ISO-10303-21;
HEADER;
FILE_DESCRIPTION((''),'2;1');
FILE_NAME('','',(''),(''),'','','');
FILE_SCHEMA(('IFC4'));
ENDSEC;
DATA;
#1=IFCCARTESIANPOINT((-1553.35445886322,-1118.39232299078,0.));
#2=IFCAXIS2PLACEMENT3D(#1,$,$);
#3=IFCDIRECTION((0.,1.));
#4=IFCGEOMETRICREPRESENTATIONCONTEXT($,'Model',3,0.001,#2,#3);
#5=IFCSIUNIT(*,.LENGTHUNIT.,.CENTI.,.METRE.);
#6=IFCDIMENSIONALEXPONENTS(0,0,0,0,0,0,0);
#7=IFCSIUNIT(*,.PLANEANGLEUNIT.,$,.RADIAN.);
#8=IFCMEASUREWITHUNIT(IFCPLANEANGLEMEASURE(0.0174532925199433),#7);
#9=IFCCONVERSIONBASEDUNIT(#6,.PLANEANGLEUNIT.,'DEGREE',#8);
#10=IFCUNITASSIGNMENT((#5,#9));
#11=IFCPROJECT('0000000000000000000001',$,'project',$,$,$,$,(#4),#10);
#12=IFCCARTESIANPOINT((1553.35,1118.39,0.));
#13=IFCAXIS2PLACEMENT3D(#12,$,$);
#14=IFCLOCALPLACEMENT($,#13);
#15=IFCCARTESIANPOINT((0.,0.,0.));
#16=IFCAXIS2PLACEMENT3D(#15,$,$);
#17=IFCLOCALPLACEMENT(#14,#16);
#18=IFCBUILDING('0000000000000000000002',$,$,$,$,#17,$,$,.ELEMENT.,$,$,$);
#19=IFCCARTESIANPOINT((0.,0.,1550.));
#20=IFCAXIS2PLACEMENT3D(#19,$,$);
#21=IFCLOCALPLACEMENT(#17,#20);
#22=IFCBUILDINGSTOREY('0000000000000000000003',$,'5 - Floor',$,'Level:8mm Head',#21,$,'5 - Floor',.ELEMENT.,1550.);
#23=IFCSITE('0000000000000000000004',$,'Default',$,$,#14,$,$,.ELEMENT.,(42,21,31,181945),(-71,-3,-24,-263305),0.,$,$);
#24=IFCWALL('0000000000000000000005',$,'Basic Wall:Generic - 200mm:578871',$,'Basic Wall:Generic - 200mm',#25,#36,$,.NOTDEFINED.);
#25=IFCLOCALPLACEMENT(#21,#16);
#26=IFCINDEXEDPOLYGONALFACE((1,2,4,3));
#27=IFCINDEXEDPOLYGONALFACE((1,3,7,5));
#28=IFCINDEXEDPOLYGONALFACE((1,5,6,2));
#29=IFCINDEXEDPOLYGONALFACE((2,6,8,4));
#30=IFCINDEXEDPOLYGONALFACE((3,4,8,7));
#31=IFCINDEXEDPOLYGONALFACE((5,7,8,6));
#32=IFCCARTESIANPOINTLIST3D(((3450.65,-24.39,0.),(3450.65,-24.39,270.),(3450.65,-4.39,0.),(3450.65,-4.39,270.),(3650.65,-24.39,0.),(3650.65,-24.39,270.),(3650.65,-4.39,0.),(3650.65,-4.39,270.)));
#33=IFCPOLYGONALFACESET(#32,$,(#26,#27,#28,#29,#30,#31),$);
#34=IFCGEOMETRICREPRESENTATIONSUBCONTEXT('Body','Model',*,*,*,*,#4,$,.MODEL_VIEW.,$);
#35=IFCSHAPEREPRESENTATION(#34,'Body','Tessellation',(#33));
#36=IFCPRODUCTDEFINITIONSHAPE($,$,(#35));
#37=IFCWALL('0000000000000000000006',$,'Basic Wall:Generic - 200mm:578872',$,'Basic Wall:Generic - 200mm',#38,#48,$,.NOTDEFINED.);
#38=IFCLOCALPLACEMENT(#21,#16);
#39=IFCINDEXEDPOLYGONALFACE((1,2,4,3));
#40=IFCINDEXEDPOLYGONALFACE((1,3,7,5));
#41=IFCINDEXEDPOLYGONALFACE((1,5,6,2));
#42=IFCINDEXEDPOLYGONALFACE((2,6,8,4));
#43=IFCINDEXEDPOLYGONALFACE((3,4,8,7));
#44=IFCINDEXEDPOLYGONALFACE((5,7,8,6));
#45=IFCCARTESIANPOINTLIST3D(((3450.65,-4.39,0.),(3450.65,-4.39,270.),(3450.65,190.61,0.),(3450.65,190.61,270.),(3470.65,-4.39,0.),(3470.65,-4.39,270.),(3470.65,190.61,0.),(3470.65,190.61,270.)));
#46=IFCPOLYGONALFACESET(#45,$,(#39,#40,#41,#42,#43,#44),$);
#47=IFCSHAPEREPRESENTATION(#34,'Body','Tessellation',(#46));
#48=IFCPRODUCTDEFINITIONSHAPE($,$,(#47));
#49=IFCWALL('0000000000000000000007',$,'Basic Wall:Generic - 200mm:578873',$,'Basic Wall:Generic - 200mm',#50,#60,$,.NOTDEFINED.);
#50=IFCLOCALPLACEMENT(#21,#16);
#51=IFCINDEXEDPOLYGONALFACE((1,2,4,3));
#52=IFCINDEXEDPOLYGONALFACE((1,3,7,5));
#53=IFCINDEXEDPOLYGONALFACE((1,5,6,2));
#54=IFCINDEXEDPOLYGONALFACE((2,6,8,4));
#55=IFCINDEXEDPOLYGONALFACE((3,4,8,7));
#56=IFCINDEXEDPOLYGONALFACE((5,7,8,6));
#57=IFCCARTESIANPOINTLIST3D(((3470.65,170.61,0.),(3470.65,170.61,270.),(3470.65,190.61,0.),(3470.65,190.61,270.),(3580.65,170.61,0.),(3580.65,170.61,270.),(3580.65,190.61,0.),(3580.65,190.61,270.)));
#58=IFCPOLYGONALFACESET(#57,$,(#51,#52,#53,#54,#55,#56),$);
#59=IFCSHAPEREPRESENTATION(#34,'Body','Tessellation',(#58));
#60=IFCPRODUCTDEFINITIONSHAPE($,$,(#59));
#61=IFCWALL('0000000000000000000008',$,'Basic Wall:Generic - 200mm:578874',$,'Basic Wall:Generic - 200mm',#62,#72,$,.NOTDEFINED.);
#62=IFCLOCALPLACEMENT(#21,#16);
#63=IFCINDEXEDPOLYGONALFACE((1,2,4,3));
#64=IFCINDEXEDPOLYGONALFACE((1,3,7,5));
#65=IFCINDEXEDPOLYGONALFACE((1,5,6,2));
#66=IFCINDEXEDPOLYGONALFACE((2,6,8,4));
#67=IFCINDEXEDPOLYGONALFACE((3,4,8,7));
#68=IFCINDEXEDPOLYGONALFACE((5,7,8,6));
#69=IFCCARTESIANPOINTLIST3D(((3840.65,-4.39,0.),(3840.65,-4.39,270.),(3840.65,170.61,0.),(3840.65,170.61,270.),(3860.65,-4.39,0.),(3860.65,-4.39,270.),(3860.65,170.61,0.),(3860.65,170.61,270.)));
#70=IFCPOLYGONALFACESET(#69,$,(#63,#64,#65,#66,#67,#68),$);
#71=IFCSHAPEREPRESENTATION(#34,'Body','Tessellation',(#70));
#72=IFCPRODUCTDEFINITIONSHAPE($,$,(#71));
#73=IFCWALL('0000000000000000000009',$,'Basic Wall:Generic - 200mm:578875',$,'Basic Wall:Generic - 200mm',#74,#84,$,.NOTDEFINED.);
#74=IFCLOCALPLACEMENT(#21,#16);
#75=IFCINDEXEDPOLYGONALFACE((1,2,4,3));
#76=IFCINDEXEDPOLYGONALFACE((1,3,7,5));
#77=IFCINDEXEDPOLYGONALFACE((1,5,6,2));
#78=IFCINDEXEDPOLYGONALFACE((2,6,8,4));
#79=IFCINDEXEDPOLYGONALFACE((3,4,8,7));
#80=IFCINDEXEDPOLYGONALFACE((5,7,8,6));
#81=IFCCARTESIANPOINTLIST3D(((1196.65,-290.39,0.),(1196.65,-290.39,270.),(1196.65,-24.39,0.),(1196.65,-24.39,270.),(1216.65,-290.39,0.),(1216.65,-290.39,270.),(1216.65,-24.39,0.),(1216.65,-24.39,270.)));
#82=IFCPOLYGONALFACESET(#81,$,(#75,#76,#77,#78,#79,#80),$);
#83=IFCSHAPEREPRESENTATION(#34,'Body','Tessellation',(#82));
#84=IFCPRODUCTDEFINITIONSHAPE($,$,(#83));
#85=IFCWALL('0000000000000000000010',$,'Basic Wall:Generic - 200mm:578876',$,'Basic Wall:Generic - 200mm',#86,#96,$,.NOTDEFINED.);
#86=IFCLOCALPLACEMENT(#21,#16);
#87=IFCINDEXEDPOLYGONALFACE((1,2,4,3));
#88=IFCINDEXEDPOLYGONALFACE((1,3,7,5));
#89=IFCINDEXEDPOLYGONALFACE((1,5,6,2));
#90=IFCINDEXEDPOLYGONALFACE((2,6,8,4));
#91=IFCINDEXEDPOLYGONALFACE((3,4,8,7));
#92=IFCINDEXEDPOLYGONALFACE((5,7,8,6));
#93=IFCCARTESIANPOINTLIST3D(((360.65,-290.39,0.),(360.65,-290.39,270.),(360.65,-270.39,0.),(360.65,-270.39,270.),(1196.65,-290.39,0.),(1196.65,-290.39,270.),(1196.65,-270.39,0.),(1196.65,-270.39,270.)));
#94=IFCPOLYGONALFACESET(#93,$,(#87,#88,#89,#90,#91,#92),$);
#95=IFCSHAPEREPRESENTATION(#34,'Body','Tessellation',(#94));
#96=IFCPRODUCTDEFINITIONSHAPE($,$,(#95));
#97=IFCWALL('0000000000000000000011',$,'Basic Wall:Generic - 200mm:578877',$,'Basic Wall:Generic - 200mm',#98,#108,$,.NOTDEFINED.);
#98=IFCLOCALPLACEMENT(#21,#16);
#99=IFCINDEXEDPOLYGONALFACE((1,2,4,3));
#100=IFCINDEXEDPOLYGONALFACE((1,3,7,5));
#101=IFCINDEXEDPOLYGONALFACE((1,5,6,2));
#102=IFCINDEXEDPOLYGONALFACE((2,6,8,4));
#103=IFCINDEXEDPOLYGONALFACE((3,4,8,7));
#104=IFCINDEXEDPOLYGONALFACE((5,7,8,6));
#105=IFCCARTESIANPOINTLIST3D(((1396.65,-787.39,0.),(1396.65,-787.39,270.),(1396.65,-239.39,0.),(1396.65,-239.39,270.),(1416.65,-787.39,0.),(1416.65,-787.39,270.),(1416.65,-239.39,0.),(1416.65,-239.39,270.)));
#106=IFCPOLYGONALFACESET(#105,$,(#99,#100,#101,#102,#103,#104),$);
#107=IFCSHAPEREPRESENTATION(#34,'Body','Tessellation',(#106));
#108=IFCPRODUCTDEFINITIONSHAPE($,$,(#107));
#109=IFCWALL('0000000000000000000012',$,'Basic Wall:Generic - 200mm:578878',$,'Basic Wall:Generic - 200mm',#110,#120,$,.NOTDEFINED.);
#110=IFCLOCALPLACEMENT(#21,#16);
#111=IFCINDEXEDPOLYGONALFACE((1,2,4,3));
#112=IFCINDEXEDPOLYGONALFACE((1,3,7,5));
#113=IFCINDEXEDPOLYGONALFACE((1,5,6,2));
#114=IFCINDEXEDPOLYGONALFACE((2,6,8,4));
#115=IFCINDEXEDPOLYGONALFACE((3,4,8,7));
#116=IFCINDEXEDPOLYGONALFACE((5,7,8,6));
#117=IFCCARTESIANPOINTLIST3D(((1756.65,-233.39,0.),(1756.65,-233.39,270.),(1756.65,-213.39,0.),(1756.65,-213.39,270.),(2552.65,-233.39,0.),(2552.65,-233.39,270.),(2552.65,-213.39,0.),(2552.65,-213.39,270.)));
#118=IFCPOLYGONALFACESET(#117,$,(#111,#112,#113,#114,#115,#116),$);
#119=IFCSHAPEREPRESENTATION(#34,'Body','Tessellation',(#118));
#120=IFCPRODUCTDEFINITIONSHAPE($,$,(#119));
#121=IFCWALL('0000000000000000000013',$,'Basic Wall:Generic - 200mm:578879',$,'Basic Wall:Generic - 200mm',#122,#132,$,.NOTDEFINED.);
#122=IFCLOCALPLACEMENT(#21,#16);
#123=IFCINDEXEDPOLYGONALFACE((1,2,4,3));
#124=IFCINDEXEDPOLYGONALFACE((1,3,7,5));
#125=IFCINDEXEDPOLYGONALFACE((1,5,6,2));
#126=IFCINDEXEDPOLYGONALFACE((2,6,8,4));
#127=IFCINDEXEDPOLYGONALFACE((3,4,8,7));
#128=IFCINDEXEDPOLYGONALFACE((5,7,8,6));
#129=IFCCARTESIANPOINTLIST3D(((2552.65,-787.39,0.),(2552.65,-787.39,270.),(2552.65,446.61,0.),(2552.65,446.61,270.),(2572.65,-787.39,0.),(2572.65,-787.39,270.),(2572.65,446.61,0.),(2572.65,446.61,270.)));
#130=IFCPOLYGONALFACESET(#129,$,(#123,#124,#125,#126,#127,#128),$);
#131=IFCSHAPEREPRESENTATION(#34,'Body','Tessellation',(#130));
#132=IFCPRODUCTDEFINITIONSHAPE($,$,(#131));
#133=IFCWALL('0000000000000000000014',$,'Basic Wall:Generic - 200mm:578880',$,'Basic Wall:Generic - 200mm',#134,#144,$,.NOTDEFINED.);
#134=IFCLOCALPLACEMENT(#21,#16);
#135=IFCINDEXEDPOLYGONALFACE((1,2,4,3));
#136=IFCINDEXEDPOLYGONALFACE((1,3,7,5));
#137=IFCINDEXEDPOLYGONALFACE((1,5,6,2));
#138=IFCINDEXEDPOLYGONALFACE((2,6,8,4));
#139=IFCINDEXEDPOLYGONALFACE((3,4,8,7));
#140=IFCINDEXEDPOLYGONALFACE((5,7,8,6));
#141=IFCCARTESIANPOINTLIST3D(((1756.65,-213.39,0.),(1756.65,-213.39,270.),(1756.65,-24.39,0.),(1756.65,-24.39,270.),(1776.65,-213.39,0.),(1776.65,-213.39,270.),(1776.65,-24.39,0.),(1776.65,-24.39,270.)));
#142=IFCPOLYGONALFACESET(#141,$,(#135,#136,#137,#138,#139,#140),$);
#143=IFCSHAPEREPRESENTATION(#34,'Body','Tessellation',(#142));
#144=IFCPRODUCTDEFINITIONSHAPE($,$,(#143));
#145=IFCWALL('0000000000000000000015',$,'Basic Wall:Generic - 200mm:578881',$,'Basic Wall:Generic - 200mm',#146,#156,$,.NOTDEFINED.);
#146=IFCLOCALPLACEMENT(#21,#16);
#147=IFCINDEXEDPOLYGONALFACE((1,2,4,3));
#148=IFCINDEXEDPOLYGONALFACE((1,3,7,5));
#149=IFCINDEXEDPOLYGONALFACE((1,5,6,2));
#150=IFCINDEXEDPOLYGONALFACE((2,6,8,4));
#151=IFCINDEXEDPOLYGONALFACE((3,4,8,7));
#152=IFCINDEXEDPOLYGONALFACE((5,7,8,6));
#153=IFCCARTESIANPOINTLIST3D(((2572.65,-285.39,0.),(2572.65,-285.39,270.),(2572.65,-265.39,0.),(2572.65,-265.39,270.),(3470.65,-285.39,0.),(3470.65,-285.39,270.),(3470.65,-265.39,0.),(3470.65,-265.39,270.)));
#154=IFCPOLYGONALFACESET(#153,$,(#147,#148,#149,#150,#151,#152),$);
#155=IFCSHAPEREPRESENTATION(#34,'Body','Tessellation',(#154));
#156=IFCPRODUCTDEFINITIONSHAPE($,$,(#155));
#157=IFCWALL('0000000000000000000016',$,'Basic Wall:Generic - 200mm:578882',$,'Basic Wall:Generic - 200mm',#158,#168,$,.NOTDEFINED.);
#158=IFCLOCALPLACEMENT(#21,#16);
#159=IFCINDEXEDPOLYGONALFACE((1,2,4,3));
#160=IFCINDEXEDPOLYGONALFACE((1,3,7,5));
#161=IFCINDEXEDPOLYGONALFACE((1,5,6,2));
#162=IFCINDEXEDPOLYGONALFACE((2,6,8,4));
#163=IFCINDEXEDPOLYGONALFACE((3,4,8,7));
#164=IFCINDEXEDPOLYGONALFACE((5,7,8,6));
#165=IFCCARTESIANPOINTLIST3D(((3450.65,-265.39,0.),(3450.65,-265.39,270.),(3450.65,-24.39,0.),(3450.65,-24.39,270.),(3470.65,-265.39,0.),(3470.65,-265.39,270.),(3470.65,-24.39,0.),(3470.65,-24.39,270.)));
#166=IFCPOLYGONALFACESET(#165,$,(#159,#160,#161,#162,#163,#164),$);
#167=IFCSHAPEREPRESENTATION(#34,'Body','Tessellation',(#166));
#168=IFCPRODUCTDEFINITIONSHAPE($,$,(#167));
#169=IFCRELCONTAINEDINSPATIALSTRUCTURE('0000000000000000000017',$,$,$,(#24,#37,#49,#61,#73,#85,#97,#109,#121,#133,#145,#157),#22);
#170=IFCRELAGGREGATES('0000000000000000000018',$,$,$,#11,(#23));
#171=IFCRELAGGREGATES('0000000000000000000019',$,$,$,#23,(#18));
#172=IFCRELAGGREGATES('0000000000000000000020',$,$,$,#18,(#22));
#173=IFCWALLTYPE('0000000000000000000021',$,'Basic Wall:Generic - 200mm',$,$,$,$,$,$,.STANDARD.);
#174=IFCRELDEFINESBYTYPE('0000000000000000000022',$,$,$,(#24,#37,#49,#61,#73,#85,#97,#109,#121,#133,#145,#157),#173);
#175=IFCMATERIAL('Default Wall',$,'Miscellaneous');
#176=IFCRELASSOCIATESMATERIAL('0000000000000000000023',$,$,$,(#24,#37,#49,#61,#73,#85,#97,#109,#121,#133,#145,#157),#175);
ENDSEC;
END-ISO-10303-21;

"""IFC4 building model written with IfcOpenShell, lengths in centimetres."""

from ifc_helpers import new_model, entity, si_unit, converted_unit, direction, frame, origin, place, context, subcontext, project, spatial, indexed_curve, outline, extrude, material, type_object, element, save


model = new_model("IFC4")

# Units and contexts
model_context = context("Model", 3, precision=0.001, world=frame((-1553.35445886322, -1118.39232299078, 0.0)), true_north=direction((0.0, 1.0)))
body_context = subcontext(model_context, "Body", "Model", "MODEL_VIEW")
ifc_project = project(units=[si_unit("LENGTHUNIT", "METRE", prefix="CENTI"), converted_unit("PLANEANGLEUNIT", "DEGREE", entity("IfcPlaneAngleMeasure", 0.0174532925199433), si_unit("PLANEANGLEUNIT", "RADIAN"), dimensions=[0, 0, 0, 0, 0, 0, 0])], contexts=[model_context])

# Site, building, storey
site_placement = place(None, frame((1553.35, 1118.39, 0.0)))
site = spatial("IfcSite", under=ifc_project, at=site_placement, Name="Default", CompositionType="ELEMENT", RefLatitude=(42, 21, 31, 181945), RefLongitude=(-71, -3, -24, -263305), RefElevation=0.0)
building_placement = place(site_placement, origin())
building = spatial("IfcBuilding", under=site, at=building_placement, CompositionType="ELEMENT")
storey_placement = place(building_placement, frame((0.0, 0.0, 1550.0)))
storey = spatial("IfcBuildingStorey", under=building, at=storey_placement, Name="5 - Floor", ObjectType="Level:8mm Head", LongName="5 - Floor", CompositionType="ELEMENT", Elevation=1550.0)

# Walls
ifc_material_1 = material(Name="Default Wall", Category="Miscellaneous")
wall_type_1 = type_object("IfcWallType", Name="Basic Wall:Generic - 200mm", PredefinedType="STANDARD")
wall_1_placement = place(storey_placement, frame((3650.65, -14.39, 0.0), z_axis=(0.0, 0.0, 1.0), x_axis=(-1.0, 0.0, 0.0)))
element("IfcWall", 1, at=wall_1_placement, inside=storey, type_object=wall_type_1, material=ifc_material_1, Name="Basic Wall:Generic - 200mm:578871", ObjectType="Basic Wall:Generic - 200mm", PredefinedType="NOTDEFINED", context=body_context, shape_type="SweptSolid", body=[
    extrude(outline(indexed_curve([(200.0, 10.0), (0.0, 10.0), (0.0, -10.0), (200.0, -10.0), (200.0, 10.0)], self_intersect=False)), origin(), (0.0, 0.0, 1.0), 270.0),
])
wall_2_placement = place(storey_placement, frame((3460.65, -4.39, 0.0), z_axis=(0.0, 0.0, 1.0), x_axis=(0.0, 1.0, 0.0)))
element("IfcWall", 2, at=wall_2_placement, inside=storey, type_object=wall_type_1, material=ifc_material_1, Name="Basic Wall:Generic - 200mm:578872", ObjectType="Basic Wall:Generic - 200mm", PredefinedType="NOTDEFINED", context=body_context, shape_type="SweptSolid", body=[
    extrude(outline(indexed_curve([(195.0, 10.0), (0.0, 10.0), (0.0, -10.0), (195.0, -10.0), (195.0, 10.0)], self_intersect=False)), origin(), (0.0, 0.0, 1.0), 270.0),
])
wall_3_placement = place(storey_placement, frame((3470.65, 180.61, 0.0)))
element("IfcWall", 3, at=wall_3_placement, inside=storey, type_object=wall_type_1, material=ifc_material_1, Name="Basic Wall:Generic - 200mm:578873", ObjectType="Basic Wall:Generic - 200mm", PredefinedType="NOTDEFINED", context=body_context, shape_type="SweptSolid", body=[
    extrude(outline(indexed_curve([(110.0, 10.0), (0.0, 10.0), (0.0, -10.0), (110.0, -10.0), (110.0, 10.0)], self_intersect=False)), origin(), (0.0, 0.0, 1.0), 270.0),
])
wall_4_placement = place(storey_placement, frame((3850.65, 170.61, 0.0), z_axis=(0.0, 0.0, 1.0), x_axis=(0.0, -1.0, 0.0)))
element("IfcWall", 4, at=wall_4_placement, inside=storey, type_object=wall_type_1, material=ifc_material_1, Name="Basic Wall:Generic - 200mm:578874", ObjectType="Basic Wall:Generic - 200mm", PredefinedType="NOTDEFINED", context=body_context, shape_type="SweptSolid", body=[
    extrude(outline(indexed_curve([(175.0, 10.0), (0.0, 10.0), (0.0, -10.0), (175.0, -10.0), (175.0, 10.0)], self_intersect=False)), origin(), (0.0, 0.0, 1.0), 270.0),
])
wall_5_placement = place(storey_placement, frame((1206.65, -24.39, 0.0), z_axis=(0.0, 0.0, 1.0), x_axis=(0.0, -1.0, 0.0)))
element("IfcWall", 5, at=wall_5_placement, inside=storey, type_object=wall_type_1, material=ifc_material_1, Name="Basic Wall:Generic - 200mm:578875", ObjectType="Basic Wall:Generic - 200mm", PredefinedType="NOTDEFINED", context=body_context, shape_type="SweptSolid", body=[
    extrude(outline(indexed_curve([(266.0, 10.0), (0.0, 10.0), (0.0, -10.0), (266.0, -10.0), (266.0, 10.0)], self_intersect=False)), origin(), (0.0, 0.0, 1.0), 270.0),
])
wall_6_placement = place(storey_placement, frame((1196.65, -280.39, 0.0), z_axis=(0.0, 0.0, 1.0), x_axis=(-1.0, 0.0, 0.0)))
element("IfcWall", 6, at=wall_6_placement, inside=storey, type_object=wall_type_1, material=ifc_material_1, Name="Basic Wall:Generic - 200mm:578876", ObjectType="Basic Wall:Generic - 200mm", PredefinedType="NOTDEFINED", context=body_context, shape_type="SweptSolid", body=[
    extrude(outline(indexed_curve([(836.0, 10.0), (0.0, 10.0), (0.0, -10.0), (836.0, -10.0), (836.0, 10.0)], self_intersect=False)), origin(), (0.0, 0.0, 1.0), 270.0),
])
wall_7_placement = place(storey_placement, frame((1406.65, -239.39, 0.0), z_axis=(0.0, 0.0, 1.0), x_axis=(0.0, -1.0, 0.0)))
element("IfcWall", 7, at=wall_7_placement, inside=storey, type_object=wall_type_1, material=ifc_material_1, Name="Basic Wall:Generic - 200mm:578877", ObjectType="Basic Wall:Generic - 200mm", PredefinedType="NOTDEFINED", context=body_context, shape_type="SweptSolid", body=[
    extrude(outline(indexed_curve([(548.0, 10.0), (0.0, 10.0), (0.0, -10.0), (548.0, -10.0), (548.0, 10.0)], self_intersect=False)), origin(), (0.0, 0.0, 1.0), 270.0),
])
wall_8_placement = place(storey_placement, frame((1756.65, -223.39, 0.0)))
element("IfcWall", 8, at=wall_8_placement, inside=storey, type_object=wall_type_1, material=ifc_material_1, Name="Basic Wall:Generic - 200mm:578878", ObjectType="Basic Wall:Generic - 200mm", PredefinedType="NOTDEFINED", context=body_context, shape_type="SweptSolid", body=[
    extrude(outline(indexed_curve([(796.0, 10.0), (0.0, 10.0), (0.0, -10.0), (796.0, -10.0), (796.0, 10.0)], self_intersect=False)), origin(), (0.0, 0.0, 1.0), 270.0),
])
wall_9_placement = place(storey_placement, frame((2562.65, 446.61, 0.0), z_axis=(0.0, 0.0, 1.0), x_axis=(0.0, -1.0, 0.0)))
element("IfcWall", 9, at=wall_9_placement, inside=storey, type_object=wall_type_1, material=ifc_material_1, Name="Basic Wall:Generic - 200mm:578879", ObjectType="Basic Wall:Generic - 200mm", PredefinedType="NOTDEFINED", context=body_context, shape_type="SweptSolid", body=[
    extrude(outline(indexed_curve([(1234.0, 10.0), (0.0, 10.0), (0.0, -10.0), (1234.0, -10.0), (1234.0, 10.0)], self_intersect=False)), origin(), (0.0, 0.0, 1.0), 270.0),
])
wall_10_placement = place(storey_placement, frame((1766.65, -24.39, 0.0), z_axis=(0.0, 0.0, 1.0), x_axis=(0.0, -1.0, 0.0)))
element("IfcWall", 10, at=wall_10_placement, inside=storey, type_object=wall_type_1, material=ifc_material_1, Name="Basic Wall:Generic - 200mm:578880", ObjectType="Basic Wall:Generic - 200mm", PredefinedType="NOTDEFINED", context=body_context, shape_type="SweptSolid", body=[
    extrude(outline(indexed_curve([(189.0, 10.0), (0.0, 10.0), (0.0, -10.0), (189.0, -10.0), (189.0, 10.0)], self_intersect=False)), origin(), (0.0, 0.0, 1.0), 270.0),
])
wall_11_placement = place(storey_placement, frame((2572.65, -275.39, 0.0)))
element("IfcWall", 11, at=wall_11_placement, inside=storey, type_object=wall_type_1, material=ifc_material_1, Name="Basic Wall:Generic - 200mm:578881", ObjectType="Basic Wall:Generic - 200mm", PredefinedType="NOTDEFINED", context=body_context, shape_type="SweptSolid", body=[
    extrude(outline(indexed_curve([(898.0, 10.0), (0.0, 10.0), (0.0, -10.0), (898.0, -10.0), (898.0, 10.0)], self_intersect=False)), origin(), (0.0, 0.0, 1.0), 270.0),
])
wall_12_placement = place(storey_placement, frame((3460.65, -24.39, 0.0), z_axis=(0.0, 0.0, 1.0), x_axis=(0.0, -1.0, 0.0)))
element("IfcWall", 12, at=wall_12_placement, inside=storey, type_object=wall_type_1, material=ifc_material_1, Name="Basic Wall:Generic - 200mm:578882", ObjectType="Basic Wall:Generic - 200mm", PredefinedType="NOTDEFINED", context=body_context, shape_type="SweptSolid", body=[
    extrude(outline(indexed_curve([(241.0, 10.0), (0.0, 10.0), (0.0, -10.0), (241.0, -10.0), (241.0, 10.0)], self_intersect=False)), origin(), (0.0, 0.0, 1.0), 270.0),
])

save(model, "model.ifc")
